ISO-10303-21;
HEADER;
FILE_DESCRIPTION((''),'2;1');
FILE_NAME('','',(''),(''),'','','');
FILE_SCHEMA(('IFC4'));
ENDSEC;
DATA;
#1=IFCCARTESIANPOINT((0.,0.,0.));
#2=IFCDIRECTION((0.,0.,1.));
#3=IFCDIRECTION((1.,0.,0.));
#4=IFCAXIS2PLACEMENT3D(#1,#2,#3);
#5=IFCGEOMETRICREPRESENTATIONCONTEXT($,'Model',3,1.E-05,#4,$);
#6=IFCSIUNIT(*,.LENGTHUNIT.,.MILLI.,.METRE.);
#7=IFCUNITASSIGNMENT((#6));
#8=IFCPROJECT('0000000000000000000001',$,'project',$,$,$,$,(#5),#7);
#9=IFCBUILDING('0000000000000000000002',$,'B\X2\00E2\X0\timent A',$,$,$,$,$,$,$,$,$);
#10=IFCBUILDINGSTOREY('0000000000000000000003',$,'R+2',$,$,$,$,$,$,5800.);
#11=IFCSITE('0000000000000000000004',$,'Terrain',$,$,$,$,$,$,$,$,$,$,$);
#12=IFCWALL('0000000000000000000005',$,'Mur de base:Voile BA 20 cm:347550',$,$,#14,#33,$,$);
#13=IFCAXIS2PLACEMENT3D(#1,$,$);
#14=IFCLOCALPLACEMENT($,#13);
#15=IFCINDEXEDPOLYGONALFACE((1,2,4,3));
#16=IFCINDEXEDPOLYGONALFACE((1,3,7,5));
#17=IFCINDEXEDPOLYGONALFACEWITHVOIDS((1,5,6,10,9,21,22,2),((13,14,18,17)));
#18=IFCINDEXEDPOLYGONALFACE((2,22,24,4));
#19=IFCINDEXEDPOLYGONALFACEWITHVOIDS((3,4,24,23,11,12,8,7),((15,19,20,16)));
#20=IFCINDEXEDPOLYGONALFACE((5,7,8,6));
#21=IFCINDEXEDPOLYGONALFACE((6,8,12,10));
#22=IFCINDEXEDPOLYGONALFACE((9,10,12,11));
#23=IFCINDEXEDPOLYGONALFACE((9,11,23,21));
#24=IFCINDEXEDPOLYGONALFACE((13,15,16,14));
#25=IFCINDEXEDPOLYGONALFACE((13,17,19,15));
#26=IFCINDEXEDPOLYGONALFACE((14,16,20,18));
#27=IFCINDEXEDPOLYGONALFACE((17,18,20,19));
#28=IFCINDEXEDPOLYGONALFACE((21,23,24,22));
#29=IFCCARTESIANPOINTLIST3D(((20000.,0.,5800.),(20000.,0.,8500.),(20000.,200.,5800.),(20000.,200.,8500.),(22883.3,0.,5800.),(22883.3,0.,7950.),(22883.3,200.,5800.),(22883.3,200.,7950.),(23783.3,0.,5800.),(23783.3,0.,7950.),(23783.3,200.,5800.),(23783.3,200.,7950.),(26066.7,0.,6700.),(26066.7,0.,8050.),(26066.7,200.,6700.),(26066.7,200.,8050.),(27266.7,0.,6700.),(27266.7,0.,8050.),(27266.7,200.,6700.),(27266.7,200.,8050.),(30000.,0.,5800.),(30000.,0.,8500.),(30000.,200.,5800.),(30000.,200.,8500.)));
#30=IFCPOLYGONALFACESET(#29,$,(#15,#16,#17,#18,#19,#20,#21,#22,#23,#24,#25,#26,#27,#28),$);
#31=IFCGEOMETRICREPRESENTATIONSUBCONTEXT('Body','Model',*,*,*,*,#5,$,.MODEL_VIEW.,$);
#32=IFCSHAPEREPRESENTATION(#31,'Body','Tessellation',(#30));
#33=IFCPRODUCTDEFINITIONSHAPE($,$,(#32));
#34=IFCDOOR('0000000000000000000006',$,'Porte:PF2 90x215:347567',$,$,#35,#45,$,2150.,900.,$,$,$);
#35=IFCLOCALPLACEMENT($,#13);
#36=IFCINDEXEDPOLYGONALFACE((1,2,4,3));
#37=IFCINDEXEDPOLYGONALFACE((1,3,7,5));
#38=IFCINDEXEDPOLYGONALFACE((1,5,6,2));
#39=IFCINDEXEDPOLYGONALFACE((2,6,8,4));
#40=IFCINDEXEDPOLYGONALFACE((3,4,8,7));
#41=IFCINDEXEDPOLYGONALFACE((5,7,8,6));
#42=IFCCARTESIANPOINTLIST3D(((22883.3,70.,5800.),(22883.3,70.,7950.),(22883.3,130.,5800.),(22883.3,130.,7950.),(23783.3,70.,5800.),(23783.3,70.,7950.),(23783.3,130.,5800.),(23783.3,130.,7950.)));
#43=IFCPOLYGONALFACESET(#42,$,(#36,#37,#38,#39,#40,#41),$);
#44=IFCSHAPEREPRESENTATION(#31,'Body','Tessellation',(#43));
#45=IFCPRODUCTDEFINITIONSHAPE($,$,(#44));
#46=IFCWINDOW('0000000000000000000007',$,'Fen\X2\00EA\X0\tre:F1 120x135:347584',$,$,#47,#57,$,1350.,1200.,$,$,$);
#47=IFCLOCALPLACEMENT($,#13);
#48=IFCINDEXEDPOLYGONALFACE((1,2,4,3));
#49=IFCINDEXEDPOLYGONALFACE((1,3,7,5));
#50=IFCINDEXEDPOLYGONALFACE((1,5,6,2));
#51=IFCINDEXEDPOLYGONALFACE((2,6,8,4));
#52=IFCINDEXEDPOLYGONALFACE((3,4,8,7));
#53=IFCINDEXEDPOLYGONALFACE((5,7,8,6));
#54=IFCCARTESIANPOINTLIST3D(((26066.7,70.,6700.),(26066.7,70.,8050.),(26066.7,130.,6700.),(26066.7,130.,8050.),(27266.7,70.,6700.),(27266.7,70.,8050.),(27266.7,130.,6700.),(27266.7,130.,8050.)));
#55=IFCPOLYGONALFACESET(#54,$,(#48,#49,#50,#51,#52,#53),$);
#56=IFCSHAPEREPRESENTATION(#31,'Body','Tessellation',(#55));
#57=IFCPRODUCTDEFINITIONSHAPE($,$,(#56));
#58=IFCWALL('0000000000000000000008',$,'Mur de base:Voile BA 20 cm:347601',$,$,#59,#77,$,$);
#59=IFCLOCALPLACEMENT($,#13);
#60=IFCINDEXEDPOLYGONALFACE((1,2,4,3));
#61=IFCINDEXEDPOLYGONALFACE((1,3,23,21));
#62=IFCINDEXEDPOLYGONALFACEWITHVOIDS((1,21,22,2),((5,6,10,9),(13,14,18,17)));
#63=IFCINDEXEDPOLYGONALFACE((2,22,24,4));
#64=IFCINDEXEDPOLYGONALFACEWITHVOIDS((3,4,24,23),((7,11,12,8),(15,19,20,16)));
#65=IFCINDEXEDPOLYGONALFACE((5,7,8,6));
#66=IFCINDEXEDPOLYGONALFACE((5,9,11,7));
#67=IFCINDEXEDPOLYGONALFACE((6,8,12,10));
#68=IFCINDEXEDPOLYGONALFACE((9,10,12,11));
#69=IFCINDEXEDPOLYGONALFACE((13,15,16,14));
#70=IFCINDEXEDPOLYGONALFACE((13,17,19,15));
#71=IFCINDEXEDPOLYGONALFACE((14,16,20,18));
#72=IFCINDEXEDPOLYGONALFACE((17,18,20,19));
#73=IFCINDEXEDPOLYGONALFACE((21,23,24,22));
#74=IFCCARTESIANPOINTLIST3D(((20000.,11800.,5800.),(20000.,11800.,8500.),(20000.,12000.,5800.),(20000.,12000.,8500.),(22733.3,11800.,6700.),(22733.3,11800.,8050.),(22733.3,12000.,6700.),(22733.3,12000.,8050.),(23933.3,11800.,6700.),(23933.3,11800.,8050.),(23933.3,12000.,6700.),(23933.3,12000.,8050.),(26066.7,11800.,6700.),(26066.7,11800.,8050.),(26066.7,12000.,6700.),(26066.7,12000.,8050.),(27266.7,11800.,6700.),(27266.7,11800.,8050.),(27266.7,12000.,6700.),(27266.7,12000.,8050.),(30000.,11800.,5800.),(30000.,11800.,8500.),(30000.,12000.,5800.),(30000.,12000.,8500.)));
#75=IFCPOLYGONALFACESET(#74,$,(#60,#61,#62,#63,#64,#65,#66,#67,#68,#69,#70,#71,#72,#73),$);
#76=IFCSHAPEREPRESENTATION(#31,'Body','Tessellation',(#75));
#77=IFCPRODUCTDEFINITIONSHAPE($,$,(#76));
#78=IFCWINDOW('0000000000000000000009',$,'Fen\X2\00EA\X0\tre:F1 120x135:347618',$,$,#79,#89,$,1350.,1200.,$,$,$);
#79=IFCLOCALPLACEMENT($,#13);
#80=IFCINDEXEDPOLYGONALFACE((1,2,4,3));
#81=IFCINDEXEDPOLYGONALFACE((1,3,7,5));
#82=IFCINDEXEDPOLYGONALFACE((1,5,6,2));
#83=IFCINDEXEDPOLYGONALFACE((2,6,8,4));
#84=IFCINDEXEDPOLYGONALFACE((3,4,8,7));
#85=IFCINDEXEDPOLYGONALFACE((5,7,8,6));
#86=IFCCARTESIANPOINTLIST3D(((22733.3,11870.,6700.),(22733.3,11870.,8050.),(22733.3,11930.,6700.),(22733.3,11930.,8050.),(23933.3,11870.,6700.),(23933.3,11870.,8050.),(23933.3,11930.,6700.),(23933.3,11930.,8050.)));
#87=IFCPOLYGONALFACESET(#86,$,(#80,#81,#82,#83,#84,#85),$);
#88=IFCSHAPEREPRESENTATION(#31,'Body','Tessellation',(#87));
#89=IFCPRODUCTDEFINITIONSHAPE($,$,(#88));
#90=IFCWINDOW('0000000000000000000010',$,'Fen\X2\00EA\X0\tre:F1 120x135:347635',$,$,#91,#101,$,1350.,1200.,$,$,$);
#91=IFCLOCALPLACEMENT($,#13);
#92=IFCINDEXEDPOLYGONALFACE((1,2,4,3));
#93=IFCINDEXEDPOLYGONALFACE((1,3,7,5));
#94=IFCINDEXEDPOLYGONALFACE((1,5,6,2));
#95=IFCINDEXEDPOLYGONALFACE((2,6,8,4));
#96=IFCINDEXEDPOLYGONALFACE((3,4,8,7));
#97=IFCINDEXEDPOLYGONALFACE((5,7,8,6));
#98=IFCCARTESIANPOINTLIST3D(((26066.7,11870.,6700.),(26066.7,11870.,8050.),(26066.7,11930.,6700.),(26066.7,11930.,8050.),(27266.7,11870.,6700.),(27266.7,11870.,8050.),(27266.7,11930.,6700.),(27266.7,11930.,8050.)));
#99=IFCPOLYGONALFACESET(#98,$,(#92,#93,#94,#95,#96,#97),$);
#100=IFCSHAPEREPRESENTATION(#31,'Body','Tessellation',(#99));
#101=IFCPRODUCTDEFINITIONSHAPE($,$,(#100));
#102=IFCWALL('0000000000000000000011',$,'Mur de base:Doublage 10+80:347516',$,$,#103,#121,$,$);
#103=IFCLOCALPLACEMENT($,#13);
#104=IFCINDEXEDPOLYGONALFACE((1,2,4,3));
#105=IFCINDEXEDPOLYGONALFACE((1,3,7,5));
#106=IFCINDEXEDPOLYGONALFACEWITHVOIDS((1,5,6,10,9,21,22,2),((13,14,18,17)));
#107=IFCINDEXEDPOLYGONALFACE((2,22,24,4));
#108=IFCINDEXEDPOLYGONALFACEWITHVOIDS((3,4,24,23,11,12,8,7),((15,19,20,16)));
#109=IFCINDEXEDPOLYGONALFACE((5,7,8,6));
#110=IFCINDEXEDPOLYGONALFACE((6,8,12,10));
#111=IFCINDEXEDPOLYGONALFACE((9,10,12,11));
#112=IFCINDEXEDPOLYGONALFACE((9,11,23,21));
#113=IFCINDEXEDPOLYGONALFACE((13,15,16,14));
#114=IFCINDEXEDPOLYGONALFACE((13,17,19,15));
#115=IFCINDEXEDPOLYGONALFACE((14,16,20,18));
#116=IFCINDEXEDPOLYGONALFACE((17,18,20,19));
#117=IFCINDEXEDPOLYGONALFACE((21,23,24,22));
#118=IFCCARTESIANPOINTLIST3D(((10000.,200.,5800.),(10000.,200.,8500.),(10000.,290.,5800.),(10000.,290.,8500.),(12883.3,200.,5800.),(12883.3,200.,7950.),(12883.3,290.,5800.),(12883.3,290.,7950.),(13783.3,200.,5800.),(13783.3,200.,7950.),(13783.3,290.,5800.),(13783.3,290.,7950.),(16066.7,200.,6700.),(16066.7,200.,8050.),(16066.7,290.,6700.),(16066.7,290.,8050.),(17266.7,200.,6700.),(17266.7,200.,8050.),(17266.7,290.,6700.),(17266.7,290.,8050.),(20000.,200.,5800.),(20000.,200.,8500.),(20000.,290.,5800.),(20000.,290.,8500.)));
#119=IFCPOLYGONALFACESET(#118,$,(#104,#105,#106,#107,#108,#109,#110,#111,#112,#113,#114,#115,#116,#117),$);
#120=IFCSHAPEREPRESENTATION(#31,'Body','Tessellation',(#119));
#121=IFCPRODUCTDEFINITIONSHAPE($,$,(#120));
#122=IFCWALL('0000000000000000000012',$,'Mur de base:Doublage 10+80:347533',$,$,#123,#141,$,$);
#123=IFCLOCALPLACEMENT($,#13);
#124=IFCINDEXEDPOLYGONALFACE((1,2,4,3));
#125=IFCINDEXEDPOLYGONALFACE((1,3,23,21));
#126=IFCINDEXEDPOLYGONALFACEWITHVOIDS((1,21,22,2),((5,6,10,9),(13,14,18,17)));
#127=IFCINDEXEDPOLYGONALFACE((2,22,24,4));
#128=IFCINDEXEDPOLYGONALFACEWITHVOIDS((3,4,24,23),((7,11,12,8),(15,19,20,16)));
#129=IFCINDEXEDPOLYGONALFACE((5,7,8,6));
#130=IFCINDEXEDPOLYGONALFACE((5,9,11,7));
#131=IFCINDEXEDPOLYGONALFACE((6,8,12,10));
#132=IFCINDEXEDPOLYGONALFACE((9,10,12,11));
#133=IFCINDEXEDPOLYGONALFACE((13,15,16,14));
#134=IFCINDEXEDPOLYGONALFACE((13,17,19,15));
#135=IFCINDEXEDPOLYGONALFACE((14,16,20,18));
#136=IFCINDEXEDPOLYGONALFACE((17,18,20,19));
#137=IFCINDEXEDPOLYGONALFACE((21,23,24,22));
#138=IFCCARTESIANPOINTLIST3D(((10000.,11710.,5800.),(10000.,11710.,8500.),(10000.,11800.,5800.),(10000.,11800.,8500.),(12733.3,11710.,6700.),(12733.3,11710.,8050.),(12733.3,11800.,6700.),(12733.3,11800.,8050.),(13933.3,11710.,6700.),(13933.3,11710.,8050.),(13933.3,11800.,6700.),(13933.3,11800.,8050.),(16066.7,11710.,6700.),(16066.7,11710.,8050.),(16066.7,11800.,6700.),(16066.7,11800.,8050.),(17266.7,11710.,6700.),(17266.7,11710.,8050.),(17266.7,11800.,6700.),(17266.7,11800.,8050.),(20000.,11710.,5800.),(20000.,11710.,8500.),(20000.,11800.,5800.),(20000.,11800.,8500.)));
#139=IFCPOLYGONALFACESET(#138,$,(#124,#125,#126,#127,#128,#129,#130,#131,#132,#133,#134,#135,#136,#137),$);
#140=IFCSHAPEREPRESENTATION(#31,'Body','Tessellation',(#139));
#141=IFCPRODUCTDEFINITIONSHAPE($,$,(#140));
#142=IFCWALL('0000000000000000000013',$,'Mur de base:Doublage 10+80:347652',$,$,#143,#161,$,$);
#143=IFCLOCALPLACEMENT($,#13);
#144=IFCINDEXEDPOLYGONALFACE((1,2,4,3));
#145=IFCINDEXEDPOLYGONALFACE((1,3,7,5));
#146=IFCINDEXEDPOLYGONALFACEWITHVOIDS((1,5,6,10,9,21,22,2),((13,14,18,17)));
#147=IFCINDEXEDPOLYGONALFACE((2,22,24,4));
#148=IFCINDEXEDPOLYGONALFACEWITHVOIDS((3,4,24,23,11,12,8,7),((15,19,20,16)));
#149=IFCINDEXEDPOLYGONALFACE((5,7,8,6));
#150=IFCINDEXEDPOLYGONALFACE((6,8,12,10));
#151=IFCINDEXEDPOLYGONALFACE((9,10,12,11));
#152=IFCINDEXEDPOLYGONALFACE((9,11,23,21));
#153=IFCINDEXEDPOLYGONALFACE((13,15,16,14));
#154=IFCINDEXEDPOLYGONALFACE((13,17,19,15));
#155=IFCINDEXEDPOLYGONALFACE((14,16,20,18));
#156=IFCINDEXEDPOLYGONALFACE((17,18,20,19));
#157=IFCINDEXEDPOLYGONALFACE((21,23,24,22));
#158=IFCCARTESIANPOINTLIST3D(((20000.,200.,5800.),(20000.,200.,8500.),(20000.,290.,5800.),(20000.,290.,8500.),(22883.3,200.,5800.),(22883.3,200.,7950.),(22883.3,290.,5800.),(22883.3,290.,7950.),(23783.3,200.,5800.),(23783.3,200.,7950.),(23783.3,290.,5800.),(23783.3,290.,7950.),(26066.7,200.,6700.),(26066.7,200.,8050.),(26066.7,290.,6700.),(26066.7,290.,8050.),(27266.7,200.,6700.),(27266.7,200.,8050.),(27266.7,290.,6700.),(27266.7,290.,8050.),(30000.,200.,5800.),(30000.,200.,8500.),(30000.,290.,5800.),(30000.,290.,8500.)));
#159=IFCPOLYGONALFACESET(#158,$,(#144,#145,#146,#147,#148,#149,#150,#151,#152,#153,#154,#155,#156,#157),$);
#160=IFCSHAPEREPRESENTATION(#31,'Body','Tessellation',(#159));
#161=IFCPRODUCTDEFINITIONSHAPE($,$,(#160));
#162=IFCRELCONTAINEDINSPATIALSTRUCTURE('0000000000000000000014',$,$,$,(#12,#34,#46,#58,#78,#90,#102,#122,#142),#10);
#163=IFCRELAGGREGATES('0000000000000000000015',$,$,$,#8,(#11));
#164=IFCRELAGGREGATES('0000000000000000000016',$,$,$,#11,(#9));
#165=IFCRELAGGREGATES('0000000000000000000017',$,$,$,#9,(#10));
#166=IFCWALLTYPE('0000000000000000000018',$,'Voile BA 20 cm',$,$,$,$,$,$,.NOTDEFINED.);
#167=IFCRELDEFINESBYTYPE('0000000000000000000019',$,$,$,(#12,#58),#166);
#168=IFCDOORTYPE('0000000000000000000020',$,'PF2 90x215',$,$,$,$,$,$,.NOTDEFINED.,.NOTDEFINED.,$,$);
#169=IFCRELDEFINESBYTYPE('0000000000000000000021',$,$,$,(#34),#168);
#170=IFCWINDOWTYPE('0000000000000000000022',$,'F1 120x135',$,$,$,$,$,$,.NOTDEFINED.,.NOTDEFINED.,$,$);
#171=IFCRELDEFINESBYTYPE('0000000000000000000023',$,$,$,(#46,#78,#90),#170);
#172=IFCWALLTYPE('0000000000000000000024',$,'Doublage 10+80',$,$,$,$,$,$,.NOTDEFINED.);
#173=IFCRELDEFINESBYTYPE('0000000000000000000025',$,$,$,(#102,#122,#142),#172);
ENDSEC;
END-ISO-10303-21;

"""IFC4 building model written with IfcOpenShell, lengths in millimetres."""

from ifc_helpers import new_model, si_unit, frame, frame_2d, origin_with_axes, place, context, subcontext, project, spatial, rectangle, extrude, type_object, element, fill, save


model = new_model("IFC4")

# Units and contexts
model_context = context("Model", 3, precision=1e-05, world=origin_with_axes())
body_context = subcontext(model_context, "Body", "Model", "MODEL_VIEW")
ifc_project = project(units=[si_unit("LENGTHUNIT", "METRE", prefix="MILLI")], contexts=[model_context])

# Site, building, storey
site = spatial("IfcSite", under=ifc_project, Name="Terrain")
building = spatial("IfcBuilding", under=site, Name="Bâtiment A")
storey = spatial("IfcBuildingStorey", under=building, Name="R+2", Elevation=5800.0)

# Wall, openings, door, window
wall_type_1 = type_object("IfcWallType", Name="Voile BA 20 cm", PredefinedType="NOTDEFINED")
wall_1_placement = place(None, origin_with_axes())
wall_1 = element("IfcWall", 1, at=wall_1_placement, inside=storey, type_object=wall_type_1, Name="Mur de base:Voile BA 20 cm:347550", context=body_context, shape_type="SweptSolid", body=[
    extrude(rectangle(XDim=10000.0, YDim=200.0, at=frame_2d((25000.0, 100.0))), frame((0.0, 0.0, 5800.0), z_axis=(0.0, 0.0, 1.0), x_axis=(1.0, 0.0, 0.0)), (0.0, 0.0, 1.0), 2700.0),
])
opening_1_placement = place(None, origin_with_axes())
opening_1 = element("IfcOpeningElement", 2, at=opening_1_placement, cuts=wall_1, context=body_context, shape_type="SweptSolid", body=[
    extrude(rectangle(XDim=900.0, YDim=320.0, at=frame_2d((23333.3, 100.0))), frame((0.0, 0.0, 5800.0), z_axis=(0.0, 0.0, 1.0), x_axis=(1.0, 0.0, 0.0)), (0.0, 0.0, 1.0), 2150.0),
])
opening_2_placement = place(None, origin_with_axes())
opening_2 = element("IfcOpeningElement", 3, at=opening_2_placement, cuts=wall_1, context=body_context, shape_type="SweptSolid", body=[
    extrude(rectangle(XDim=1200.0, YDim=320.0, at=frame_2d((26666.7, 100.0))), frame((0.0, 0.0, 6700.0), z_axis=(0.0, 0.0, 1.0), x_axis=(1.0, 0.0, 0.0)), (0.0, 0.0, 1.0), 1350.0),
])
door_type = type_object("IfcDoorType", Name="PF2 90x215", OperationType="NOTDEFINED", PredefinedType="NOTDEFINED")
door_placement = place(None, origin_with_axes())
door = element("IfcDoor", 4, at=door_placement, inside=storey, type_object=door_type, Name="Porte:PF2 90x215:347567", OverallHeight=2150.0, OverallWidth=900.0, context=body_context, shape_type="SweptSolid", body=[
    extrude(rectangle(XDim=900.0, YDim=60.0, at=frame_2d((23333.3, 100.0))), frame((0.0, 0.0, 5800.0), z_axis=(0.0, 0.0, 1.0), x_axis=(1.0, 0.0, 0.0)), (0.0, 0.0, 1.0), 2150.0),
])
fill(opening_1, door)
window_type = type_object("IfcWindowType", Name="F1 120x135", PartitioningType="NOTDEFINED", PredefinedType="NOTDEFINED")
window_1_placement = place(None, origin_with_axes())
window_1 = element("IfcWindow", 5, at=window_1_placement, inside=storey, type_object=window_type, Name="Fenêtre:F1 120x135:347584", OverallHeight=1350.0, OverallWidth=1200.0, context=body_context, shape_type="SweptSolid", body=[
    extrude(rectangle(XDim=1200.0, YDim=60.0, at=frame_2d((26666.7, 100.0))), frame((0.0, 0.0, 6700.0), z_axis=(0.0, 0.0, 1.0), x_axis=(1.0, 0.0, 0.0)), (0.0, 0.0, 1.0), 1350.0),
])
fill(opening_2, window_1)

# Wall, openings, windows
wall_2_placement = place(None, origin_with_axes())
wall_2 = element("IfcWall", 6, at=wall_2_placement, inside=storey, type_object=wall_type_1, Name="Mur de base:Voile BA 20 cm:347601", context=body_context, shape_type="SweptSolid", body=[
    extrude(rectangle(XDim=10000.0, YDim=200.0, at=frame_2d((25000.0, 11900.0))), frame((0.0, 0.0, 5800.0), z_axis=(0.0, 0.0, 1.0), x_axis=(1.0, 0.0, 0.0)), (0.0, 0.0, 1.0), 2700.0),
])
opening_3_placement = place(None, origin_with_axes())
opening_3 = element("IfcOpeningElement", 7, at=opening_3_placement, cuts=wall_2, context=body_context, shape_type="SweptSolid", body=[
    extrude(rectangle(XDim=1200.0, YDim=320.0, at=frame_2d((23333.3, 11900.0))), frame((0.0, 0.0, 6700.0), z_axis=(0.0, 0.0, 1.0), x_axis=(1.0, 0.0, 0.0)), (0.0, 0.0, 1.0), 1350.0),
])
opening_4_placement = place(None, origin_with_axes())
opening_4 = element("IfcOpeningElement", 8, at=opening_4_placement, cuts=wall_2, context=body_context, shape_type="SweptSolid", body=[
    extrude(rectangle(XDim=1200.0, YDim=320.0, at=frame_2d((26666.7, 11900.0))), frame((0.0, 0.0, 6700.0), z_axis=(0.0, 0.0, 1.0), x_axis=(1.0, 0.0, 0.0)), (0.0, 0.0, 1.0), 1350.0),
])
window_2_placement = place(None, origin_with_axes())
window_2 = element("IfcWindow", 9, at=window_2_placement, inside=storey, type_object=window_type, Name="Fenêtre:F1 120x135:347618", OverallHeight=1350.0, OverallWidth=1200.0, context=body_context, shape_type="SweptSolid", body=[
    extrude(rectangle(XDim=1200.0, YDim=60.0, at=frame_2d((23333.3, 11900.0))), frame((0.0, 0.0, 6700.0), z_axis=(0.0, 0.0, 1.0), x_axis=(1.0, 0.0, 0.0)), (0.0, 0.0, 1.0), 1350.0),
])
fill(opening_3, window_2)
window_3_placement = place(None, origin_with_axes())
window_3 = element("IfcWindow", 10, at=window_3_placement, inside=storey, type_object=window_type, Name="Fenêtre:F1 120x135:347635", OverallHeight=1350.0, OverallWidth=1200.0, context=body_context, shape_type="SweptSolid", body=[
    extrude(rectangle(XDim=1200.0, YDim=60.0, at=frame_2d((26666.7, 11900.0))), frame((0.0, 0.0, 6700.0), z_axis=(0.0, 0.0, 1.0), x_axis=(1.0, 0.0, 0.0)), (0.0, 0.0, 1.0), 1350.0),
])
fill(opening_4, window_3)

# Walls, openings
wall_type_2 = type_object("IfcWallType", Name="Doublage 10+80", PredefinedType="NOTDEFINED")
wall_3_placement = place(None, origin_with_axes())
wall_3 = element("IfcWall", 11, at=wall_3_placement, inside=storey, type_object=wall_type_2, Name="Mur de base:Doublage 10+80:347516", context=body_context, shape_type="SweptSolid", body=[
    extrude(rectangle(XDim=10000.0, YDim=90.0, at=frame_2d((15000.0, 245.0))), frame((0.0, 0.0, 5800.0), z_axis=(0.0, 0.0, 1.0), x_axis=(1.0, 0.0, 0.0)), (0.0, 0.0, 1.0), 2700.0),
])
opening_5_placement = place(None, origin_with_axes())
element("IfcOpeningElement", 12, at=opening_5_placement, cuts=wall_3, context=body_context, shape_type="SweptSolid", body=[
    extrude(rectangle(XDim=900.0, YDim=210.0, at=frame_2d((13333.3, 245.0))), frame((0.0, 0.0, 5800.0), z_axis=(0.0, 0.0, 1.0), x_axis=(1.0, 0.0, 0.0)), (0.0, 0.0, 1.0), 2150.0),
])
opening_6_placement = place(None, origin_with_axes())
element("IfcOpeningElement", 13, at=opening_6_placement, cuts=wall_3, context=body_context, shape_type="SweptSolid", body=[
    extrude(rectangle(XDim=1200.0, YDim=210.0, at=frame_2d((16666.7, 245.0))), frame((0.0, 0.0, 6700.0), z_axis=(0.0, 0.0, 1.0), x_axis=(1.0, 0.0, 0.0)), (0.0, 0.0, 1.0), 1350.0),
])
wall_4_placement = place(None, origin_with_axes())
wall_4 = element("IfcWall", 14, at=wall_4_placement, inside=storey, type_object=wall_type_2, Name="Mur de base:Doublage 10+80:347533", context=body_context, shape_type="SweptSolid", body=[
    extrude(rectangle(XDim=10000.0, YDim=90.0, at=frame_2d((15000.0, 11755.0))), frame((0.0, 0.0, 5800.0), z_axis=(0.0, 0.0, 1.0), x_axis=(1.0, 0.0, 0.0)), (0.0, 0.0, 1.0), 2700.0),
])
opening_7_placement = place(None, origin_with_axes())
element("IfcOpeningElement", 15, at=opening_7_placement, cuts=wall_4, context=body_context, shape_type="SweptSolid", body=[
    extrude(rectangle(XDim=1200.0, YDim=210.0, at=frame_2d((13333.3, 11755.0))), frame((0.0, 0.0, 6700.0), z_axis=(0.0, 0.0, 1.0), x_axis=(1.0, 0.0, 0.0)), (0.0, 0.0, 1.0), 1350.0),
])
opening_8_placement = place(None, origin_with_axes())
element("IfcOpeningElement", 16, at=opening_8_placement, cuts=wall_4, context=body_context, shape_type="SweptSolid", body=[
    extrude(rectangle(XDim=1200.0, YDim=210.0, at=frame_2d((16666.7, 11755.0))), frame((0.0, 0.0, 6700.0), z_axis=(0.0, 0.0, 1.0), x_axis=(1.0, 0.0, 0.0)), (0.0, 0.0, 1.0), 1350.0),
])
wall_5_placement = place(None, origin_with_axes())
wall_5 = element("IfcWall", 17, at=wall_5_placement, inside=storey, type_object=wall_type_2, Name="Mur de base:Doublage 10+80:347652", context=body_context, shape_type="SweptSolid", body=[
    extrude(rectangle(XDim=10000.0, YDim=90.0, at=frame_2d((25000.0, 245.0))), frame((0.0, 0.0, 5800.0), z_axis=(0.0, 0.0, 1.0), x_axis=(1.0, 0.0, 0.0)), (0.0, 0.0, 1.0), 2700.0),
])
opening_9_placement = place(None, origin_with_axes())
element("IfcOpeningElement", 18, at=opening_9_placement, cuts=wall_5, context=body_context, shape_type="SweptSolid", body=[
    extrude(rectangle(XDim=900.0, YDim=210.0, at=frame_2d((23333.3, 245.0))), frame((0.0, 0.0, 5800.0), z_axis=(0.0, 0.0, 1.0), x_axis=(1.0, 0.0, 0.0)), (0.0, 0.0, 1.0), 2150.0),
])
opening_10_placement = place(None, origin_with_axes())
element("IfcOpeningElement", 19, at=opening_10_placement, cuts=wall_5, context=body_context, shape_type="SweptSolid", body=[
    extrude(rectangle(XDim=1200.0, YDim=210.0, at=frame_2d((26666.7, 245.0))), frame((0.0, 0.0, 6700.0), z_axis=(0.0, 0.0, 1.0), x_axis=(1.0, 0.0, 0.0)), (0.0, 0.0, 1.0), 1350.0),
])

save(model, "model.ifc")
